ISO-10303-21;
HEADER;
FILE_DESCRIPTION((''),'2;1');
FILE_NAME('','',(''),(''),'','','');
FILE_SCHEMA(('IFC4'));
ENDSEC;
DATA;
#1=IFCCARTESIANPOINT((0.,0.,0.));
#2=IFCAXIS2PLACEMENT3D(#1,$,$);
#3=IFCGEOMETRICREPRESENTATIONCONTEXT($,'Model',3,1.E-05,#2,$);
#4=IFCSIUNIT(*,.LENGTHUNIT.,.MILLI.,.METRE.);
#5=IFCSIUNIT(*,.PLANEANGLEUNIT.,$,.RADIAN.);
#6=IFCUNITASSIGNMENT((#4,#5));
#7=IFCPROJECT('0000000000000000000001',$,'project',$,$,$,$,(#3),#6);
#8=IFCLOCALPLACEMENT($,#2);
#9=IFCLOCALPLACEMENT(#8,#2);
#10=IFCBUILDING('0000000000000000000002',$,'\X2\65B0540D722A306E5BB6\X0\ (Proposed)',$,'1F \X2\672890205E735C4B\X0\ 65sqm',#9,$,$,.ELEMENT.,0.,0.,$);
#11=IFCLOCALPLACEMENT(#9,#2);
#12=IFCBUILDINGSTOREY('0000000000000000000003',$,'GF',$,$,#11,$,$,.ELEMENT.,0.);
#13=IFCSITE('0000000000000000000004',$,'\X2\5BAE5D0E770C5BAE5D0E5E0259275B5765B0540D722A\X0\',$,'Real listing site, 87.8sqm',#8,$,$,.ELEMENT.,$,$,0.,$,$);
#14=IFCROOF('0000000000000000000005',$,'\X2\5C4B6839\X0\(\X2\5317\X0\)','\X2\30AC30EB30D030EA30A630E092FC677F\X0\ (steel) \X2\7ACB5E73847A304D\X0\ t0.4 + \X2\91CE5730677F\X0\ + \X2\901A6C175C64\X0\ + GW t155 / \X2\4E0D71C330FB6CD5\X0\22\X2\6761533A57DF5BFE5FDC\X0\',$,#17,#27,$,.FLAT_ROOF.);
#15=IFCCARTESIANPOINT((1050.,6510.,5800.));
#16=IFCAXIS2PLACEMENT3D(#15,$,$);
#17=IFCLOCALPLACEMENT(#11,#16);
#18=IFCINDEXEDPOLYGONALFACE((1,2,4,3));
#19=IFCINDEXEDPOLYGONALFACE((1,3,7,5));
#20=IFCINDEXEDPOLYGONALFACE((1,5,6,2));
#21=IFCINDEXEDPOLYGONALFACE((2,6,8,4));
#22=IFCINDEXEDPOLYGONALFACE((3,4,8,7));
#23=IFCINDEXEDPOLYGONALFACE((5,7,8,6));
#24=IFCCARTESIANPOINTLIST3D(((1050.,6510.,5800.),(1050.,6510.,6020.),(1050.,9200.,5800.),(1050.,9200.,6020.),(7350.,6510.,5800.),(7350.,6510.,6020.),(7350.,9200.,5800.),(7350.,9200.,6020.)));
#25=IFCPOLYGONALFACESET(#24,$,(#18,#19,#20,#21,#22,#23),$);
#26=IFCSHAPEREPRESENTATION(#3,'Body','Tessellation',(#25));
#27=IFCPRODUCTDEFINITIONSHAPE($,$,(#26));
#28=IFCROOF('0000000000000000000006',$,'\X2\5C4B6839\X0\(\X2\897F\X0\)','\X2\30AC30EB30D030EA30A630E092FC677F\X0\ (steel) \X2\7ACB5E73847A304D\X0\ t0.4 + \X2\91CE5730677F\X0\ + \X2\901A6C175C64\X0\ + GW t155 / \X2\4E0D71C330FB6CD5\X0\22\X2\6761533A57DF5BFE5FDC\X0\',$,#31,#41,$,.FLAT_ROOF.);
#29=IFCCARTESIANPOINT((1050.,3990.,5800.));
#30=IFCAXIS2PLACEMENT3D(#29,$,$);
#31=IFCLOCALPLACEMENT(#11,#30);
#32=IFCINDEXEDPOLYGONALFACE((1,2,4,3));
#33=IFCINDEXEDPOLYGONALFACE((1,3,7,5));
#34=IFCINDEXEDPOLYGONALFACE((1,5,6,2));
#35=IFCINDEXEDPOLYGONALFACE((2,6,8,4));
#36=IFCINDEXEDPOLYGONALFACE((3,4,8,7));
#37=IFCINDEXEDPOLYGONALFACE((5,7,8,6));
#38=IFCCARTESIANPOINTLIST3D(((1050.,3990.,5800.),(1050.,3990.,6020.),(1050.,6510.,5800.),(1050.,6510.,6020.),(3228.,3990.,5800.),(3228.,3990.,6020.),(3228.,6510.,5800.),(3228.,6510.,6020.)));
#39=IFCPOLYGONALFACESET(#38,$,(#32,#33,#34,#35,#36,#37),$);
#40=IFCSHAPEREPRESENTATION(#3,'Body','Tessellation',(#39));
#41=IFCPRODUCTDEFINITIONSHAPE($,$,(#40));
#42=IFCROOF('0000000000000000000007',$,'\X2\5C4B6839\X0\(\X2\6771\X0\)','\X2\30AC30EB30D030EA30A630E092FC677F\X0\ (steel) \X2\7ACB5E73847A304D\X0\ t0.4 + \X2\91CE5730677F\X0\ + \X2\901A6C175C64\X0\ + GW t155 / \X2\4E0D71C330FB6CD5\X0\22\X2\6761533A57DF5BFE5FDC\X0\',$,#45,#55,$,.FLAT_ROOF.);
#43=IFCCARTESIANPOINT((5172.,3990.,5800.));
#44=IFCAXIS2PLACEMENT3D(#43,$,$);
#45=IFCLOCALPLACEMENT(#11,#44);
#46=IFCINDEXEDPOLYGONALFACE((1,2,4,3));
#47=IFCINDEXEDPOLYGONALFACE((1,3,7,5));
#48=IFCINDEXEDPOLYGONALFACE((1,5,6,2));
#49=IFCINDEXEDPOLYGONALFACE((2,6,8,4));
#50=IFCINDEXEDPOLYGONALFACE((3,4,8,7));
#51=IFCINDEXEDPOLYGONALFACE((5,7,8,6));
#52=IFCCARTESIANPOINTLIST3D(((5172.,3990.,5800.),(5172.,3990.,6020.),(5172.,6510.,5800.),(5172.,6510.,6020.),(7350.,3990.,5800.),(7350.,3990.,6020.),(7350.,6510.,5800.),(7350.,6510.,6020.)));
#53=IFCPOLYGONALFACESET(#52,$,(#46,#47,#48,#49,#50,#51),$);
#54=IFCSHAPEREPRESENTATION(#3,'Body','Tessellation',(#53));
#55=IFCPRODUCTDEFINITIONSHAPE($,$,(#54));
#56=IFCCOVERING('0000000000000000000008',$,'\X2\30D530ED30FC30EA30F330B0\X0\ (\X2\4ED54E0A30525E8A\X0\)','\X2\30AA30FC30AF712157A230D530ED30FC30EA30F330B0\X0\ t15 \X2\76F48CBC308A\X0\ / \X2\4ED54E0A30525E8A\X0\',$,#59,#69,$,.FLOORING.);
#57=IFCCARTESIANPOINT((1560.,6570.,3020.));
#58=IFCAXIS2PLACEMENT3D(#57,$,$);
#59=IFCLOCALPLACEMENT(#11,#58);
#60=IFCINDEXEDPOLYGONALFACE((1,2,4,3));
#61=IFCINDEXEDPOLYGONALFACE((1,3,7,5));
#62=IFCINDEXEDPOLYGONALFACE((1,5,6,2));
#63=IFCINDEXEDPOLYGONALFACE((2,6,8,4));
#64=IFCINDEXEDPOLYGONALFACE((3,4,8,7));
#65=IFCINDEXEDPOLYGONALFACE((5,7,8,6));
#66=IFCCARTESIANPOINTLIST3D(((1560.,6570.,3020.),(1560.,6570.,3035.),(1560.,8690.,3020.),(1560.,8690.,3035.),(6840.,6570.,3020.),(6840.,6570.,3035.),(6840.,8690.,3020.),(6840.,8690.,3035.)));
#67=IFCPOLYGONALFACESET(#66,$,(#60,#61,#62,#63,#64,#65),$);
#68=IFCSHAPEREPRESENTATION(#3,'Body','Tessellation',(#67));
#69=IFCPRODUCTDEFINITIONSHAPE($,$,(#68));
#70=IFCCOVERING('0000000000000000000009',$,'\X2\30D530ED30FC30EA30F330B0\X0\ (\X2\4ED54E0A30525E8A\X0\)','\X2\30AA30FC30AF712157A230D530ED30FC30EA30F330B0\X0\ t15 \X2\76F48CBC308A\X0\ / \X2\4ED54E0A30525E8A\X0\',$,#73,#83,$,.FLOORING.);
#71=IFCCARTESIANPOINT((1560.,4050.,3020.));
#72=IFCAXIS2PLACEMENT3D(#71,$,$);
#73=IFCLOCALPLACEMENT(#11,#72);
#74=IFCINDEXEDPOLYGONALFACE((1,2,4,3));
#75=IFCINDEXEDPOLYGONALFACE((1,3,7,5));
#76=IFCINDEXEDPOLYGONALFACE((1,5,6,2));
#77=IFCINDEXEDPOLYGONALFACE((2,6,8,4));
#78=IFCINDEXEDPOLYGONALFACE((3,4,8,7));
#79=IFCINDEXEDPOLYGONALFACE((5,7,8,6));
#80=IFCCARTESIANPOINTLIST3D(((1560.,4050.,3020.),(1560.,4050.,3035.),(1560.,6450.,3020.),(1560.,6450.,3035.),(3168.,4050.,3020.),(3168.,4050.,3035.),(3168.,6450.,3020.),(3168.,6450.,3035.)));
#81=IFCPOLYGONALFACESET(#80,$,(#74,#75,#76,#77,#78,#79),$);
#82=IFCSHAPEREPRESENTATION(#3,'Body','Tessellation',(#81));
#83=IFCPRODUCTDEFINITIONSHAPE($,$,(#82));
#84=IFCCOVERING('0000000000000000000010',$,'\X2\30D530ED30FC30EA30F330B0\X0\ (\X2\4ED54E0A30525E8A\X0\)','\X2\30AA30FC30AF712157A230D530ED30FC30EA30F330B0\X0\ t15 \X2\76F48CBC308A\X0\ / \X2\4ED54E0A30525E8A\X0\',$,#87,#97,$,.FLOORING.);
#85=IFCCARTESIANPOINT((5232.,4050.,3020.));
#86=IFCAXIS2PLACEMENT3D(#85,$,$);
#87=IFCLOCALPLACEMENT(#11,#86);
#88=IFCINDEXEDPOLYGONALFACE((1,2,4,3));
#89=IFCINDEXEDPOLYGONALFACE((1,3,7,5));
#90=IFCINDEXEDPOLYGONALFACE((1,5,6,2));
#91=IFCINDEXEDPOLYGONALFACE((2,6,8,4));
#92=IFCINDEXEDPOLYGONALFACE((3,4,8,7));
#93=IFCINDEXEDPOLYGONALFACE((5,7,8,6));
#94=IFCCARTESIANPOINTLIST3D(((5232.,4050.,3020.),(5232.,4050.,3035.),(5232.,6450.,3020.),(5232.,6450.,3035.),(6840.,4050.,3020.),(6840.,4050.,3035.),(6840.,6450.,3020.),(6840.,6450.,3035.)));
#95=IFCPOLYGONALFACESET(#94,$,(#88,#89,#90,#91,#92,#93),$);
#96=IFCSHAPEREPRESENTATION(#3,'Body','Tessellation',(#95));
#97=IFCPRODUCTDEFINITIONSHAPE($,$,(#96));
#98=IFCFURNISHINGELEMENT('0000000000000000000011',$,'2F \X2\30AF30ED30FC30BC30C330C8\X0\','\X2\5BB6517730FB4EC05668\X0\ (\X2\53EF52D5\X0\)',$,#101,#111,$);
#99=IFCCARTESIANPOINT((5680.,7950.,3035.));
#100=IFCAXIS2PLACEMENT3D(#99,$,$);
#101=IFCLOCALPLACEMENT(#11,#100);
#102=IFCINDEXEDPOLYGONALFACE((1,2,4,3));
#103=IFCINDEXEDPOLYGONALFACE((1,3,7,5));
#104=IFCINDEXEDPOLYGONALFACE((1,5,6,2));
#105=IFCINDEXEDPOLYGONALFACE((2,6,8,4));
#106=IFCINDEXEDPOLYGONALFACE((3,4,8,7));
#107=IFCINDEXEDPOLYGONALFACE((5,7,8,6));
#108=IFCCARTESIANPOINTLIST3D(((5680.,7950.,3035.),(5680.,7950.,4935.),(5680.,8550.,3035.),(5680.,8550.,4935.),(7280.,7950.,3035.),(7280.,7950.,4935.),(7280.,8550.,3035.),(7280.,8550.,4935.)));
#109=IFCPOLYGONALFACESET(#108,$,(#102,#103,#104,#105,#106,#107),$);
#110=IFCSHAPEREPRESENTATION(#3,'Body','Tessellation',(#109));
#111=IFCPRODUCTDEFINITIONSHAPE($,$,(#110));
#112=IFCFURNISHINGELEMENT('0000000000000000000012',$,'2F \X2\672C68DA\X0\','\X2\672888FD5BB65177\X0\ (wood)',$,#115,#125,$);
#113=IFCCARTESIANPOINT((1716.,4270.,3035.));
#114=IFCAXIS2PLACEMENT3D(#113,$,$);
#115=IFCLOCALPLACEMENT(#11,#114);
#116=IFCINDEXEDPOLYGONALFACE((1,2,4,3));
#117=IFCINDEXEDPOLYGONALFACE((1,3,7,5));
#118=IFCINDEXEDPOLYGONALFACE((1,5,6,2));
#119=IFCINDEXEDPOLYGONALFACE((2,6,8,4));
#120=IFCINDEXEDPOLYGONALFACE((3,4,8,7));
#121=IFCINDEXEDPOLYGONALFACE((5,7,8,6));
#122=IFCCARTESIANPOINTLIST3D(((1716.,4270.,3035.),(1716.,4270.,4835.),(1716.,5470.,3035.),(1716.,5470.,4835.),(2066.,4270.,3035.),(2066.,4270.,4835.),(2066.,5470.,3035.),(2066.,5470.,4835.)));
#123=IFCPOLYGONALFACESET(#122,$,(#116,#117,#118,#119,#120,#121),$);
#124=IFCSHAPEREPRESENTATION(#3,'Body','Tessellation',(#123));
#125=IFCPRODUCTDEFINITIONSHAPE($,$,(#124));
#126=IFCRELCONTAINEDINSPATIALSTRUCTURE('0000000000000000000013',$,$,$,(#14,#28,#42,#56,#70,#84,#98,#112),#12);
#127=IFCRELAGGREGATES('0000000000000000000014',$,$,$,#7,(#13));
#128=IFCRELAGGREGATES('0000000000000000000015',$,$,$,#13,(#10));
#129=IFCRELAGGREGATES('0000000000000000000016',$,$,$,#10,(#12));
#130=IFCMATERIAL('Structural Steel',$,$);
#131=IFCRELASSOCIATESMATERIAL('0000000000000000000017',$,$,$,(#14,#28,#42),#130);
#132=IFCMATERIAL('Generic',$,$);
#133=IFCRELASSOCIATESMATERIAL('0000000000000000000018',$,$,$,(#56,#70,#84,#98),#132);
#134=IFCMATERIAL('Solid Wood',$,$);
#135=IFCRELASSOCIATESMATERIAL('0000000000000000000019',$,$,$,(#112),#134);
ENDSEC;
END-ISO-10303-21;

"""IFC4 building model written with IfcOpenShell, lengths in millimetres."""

from ifc_helpers import new_model, si_unit, frame, frame_2d, origin, place, context, project, spatial, rectangle, extrude, material, element, save


model = new_model("IFC4")

# Units and contexts
model_context = context("Model", 3, precision=1e-05, world=origin())
ifc_project = project(units=[si_unit("LENGTHUNIT", "METRE", prefix="MILLI"), si_unit("PLANEANGLEUNIT", "RADIAN")], contexts=[model_context])

# Site, building, storey
site_placement = place(None, origin())
site = spatial("IfcSite", under=ifc_project, at=site_placement, Name="宮崎県宮崎市大字新名爪", ObjectType="Real listing site, 87.8sqm", CompositionType="ELEMENT", RefElevation=0.0)
building_placement = place(site_placement, origin())
building = spatial("IfcBuilding", under=site, at=building_placement, Name="新名爪の家 (Proposed)", ObjectType="1F 木造平屋 65sqm", CompositionType="ELEMENT", ElevationOfRefHeight=0.0, ElevationOfTerrain=0.0)
storey_placement = place(building_placement, origin())
storey = spatial("IfcBuildingStorey", under=building, at=storey_placement, Name="GF", CompositionType="ELEMENT", Elevation=0.0)

# Shared definitions
ifc_material_1 = material(Name="Solid Wood")

# Shared definitions
ifc_material_2 = material(Name="Generic")

# Roofs
ifc_material_3 = material(Name="Structural Steel")
for number, where, name in (
    (1, (1050.0, 6510.0, 5800.0), "屋根(北)"),
):
    element("IfcRoof", number, at=place(storey_placement, frame(where)), inside=storey, material=ifc_material_3, Name=name, Description="ガルバリウム鋼板 (steel) 立平葺き t0.4 + 野地板 + 通気層 + GW t155 / 不燃・法22条区域対応", PredefinedType="FLAT_ROOF", context=model_context, shape_type="SweptSolid", body=[
        extrude(rectangle(XDim=6300.0, YDim=2690.0, at=frame_2d((3150.0, 1345.0))), frame((1050.0, 6510.0, 5800.0)), (0.0, 0.0, 1.0), 220.0),
    ])
roof_1_placement = place(storey_placement, frame((1050.0, 3990.0, 5800.0)))
element("IfcRoof", 2, at=roof_1_placement, inside=storey, material=ifc_material_3, Name="屋根(西)", Description="ガルバリウム鋼板 (steel) 立平葺き t0.4 + 野地板 + 通気層 + GW t155 / 不燃・法22条区域対応", PredefinedType="FLAT_ROOF", context=model_context, shape_type="SweptSolid", body=[
    extrude(rectangle(XDim=2178.0, YDim=2520.0, at=frame_2d((1089.0, 1260.0))), frame((1050.0, 3990.0, 5800.0)), (0.0, 0.0, 1.0), 220.0),
])
roof_2_placement = place(storey_placement, frame((5172.0, 3990.0, 5800.0)))
element("IfcRoof", 3, at=roof_2_placement, inside=storey, material=ifc_material_3, Name="屋根(東)", Description="ガルバリウム鋼板 (steel) 立平葺き t0.4 + 野地板 + 通気層 + GW t155 / 不燃・法22条区域対応", PredefinedType="FLAT_ROOF", context=model_context, shape_type="SweptSolid", body=[
    extrude(rectangle(XDim=2178.0, YDim=2520.0, at=frame_2d((1089.0, 1260.0))), frame((5172.0, 3990.0, 5800.0)), (0.0, 0.0, 1.0), 220.0),
])

# Coverings
covering_1_placement = place(storey_placement, frame((1560.0, 6570.0, 3020.0)))
element("IfcCovering", 4, at=covering_1_placement, inside=storey, material=ifc_material_2, Name="フローリング (仕上げ床)", Description="オーク無垢フローリング t15 直貼り / 仕上げ床", PredefinedType="FLOORING", context=model_context, shape_type="SweptSolid", body=[
    extrude(rectangle(XDim=5280.0, YDim=2120.0, at=frame_2d((2640.0, 1060.0))), frame((1560.0, 6570.0, 3020.0)), (0.0, 0.0, 1.0), 15.0),
])
covering_2_placement = place(storey_placement, frame((1560.0, 4050.0, 3020.0)))
element("IfcCovering", 5, at=covering_2_placement, inside=storey, material=ifc_material_2, Name="フローリング (仕上げ床)", Description="オーク無垢フローリング t15 直貼り / 仕上げ床", PredefinedType="FLOORING", context=model_context, shape_type="SweptSolid", body=[
    extrude(rectangle(XDim=1608.0, YDim=2400.0, at=frame_2d((804.0, 1200.0))), frame((1560.0, 4050.0, 3020.0)), (0.0, 0.0, 1.0), 15.0),
])
covering_3_placement = place(storey_placement, frame((5232.0, 4050.0, 3020.0)))
element("IfcCovering", 6, at=covering_3_placement, inside=storey, material=ifc_material_2, Name="フローリング (仕上げ床)", Description="オーク無垢フローリング t15 直貼り / 仕上げ床", PredefinedType="FLOORING", context=model_context, shape_type="SweptSolid", body=[
    extrude(rectangle(XDim=1608.0, YDim=2400.0, at=frame_2d((804.0, 1200.0))), frame((5232.0, 4050.0, 3020.0)), (0.0, 0.0, 1.0), 15.0),
])

# Furnishing elements
furnishing_1_placement = place(storey_placement, frame((5680.0, 7950.0, 3035.0)))
element("IfcFurnishingElement", 7, at=furnishing_1_placement, inside=storey, material=ifc_material_2, Name="2F クローゼット", Description="家具・什器 (可動)", context=model_context, shape_type="SweptSolid", body=[
    extrude(rectangle(XDim=1600.0, YDim=600.0, at=frame_2d((800.0, 300.0))), frame((5680.0, 7950.0, 3035.0)), (0.0, 0.0, 1.0), 1900.0),
])
furnishing_2_placement = place(storey_placement, frame((1716.0, 4270.0, 3035.0)))
element("IfcFurnishingElement", 8, at=furnishing_2_placement, inside=storey, material=ifc_material_1, Name="2F 本棚", Description="木製家具 (wood)", context=model_context, shape_type="SweptSolid", body=[
    extrude(rectangle(XDim=350.0, YDim=1200.0, at=frame_2d((175.0, 600.0))), frame((1716.0, 4270.0, 3035.0)), (0.0, 0.0, 1.0), 1800.0),
])

save(model, "model.ifc")
